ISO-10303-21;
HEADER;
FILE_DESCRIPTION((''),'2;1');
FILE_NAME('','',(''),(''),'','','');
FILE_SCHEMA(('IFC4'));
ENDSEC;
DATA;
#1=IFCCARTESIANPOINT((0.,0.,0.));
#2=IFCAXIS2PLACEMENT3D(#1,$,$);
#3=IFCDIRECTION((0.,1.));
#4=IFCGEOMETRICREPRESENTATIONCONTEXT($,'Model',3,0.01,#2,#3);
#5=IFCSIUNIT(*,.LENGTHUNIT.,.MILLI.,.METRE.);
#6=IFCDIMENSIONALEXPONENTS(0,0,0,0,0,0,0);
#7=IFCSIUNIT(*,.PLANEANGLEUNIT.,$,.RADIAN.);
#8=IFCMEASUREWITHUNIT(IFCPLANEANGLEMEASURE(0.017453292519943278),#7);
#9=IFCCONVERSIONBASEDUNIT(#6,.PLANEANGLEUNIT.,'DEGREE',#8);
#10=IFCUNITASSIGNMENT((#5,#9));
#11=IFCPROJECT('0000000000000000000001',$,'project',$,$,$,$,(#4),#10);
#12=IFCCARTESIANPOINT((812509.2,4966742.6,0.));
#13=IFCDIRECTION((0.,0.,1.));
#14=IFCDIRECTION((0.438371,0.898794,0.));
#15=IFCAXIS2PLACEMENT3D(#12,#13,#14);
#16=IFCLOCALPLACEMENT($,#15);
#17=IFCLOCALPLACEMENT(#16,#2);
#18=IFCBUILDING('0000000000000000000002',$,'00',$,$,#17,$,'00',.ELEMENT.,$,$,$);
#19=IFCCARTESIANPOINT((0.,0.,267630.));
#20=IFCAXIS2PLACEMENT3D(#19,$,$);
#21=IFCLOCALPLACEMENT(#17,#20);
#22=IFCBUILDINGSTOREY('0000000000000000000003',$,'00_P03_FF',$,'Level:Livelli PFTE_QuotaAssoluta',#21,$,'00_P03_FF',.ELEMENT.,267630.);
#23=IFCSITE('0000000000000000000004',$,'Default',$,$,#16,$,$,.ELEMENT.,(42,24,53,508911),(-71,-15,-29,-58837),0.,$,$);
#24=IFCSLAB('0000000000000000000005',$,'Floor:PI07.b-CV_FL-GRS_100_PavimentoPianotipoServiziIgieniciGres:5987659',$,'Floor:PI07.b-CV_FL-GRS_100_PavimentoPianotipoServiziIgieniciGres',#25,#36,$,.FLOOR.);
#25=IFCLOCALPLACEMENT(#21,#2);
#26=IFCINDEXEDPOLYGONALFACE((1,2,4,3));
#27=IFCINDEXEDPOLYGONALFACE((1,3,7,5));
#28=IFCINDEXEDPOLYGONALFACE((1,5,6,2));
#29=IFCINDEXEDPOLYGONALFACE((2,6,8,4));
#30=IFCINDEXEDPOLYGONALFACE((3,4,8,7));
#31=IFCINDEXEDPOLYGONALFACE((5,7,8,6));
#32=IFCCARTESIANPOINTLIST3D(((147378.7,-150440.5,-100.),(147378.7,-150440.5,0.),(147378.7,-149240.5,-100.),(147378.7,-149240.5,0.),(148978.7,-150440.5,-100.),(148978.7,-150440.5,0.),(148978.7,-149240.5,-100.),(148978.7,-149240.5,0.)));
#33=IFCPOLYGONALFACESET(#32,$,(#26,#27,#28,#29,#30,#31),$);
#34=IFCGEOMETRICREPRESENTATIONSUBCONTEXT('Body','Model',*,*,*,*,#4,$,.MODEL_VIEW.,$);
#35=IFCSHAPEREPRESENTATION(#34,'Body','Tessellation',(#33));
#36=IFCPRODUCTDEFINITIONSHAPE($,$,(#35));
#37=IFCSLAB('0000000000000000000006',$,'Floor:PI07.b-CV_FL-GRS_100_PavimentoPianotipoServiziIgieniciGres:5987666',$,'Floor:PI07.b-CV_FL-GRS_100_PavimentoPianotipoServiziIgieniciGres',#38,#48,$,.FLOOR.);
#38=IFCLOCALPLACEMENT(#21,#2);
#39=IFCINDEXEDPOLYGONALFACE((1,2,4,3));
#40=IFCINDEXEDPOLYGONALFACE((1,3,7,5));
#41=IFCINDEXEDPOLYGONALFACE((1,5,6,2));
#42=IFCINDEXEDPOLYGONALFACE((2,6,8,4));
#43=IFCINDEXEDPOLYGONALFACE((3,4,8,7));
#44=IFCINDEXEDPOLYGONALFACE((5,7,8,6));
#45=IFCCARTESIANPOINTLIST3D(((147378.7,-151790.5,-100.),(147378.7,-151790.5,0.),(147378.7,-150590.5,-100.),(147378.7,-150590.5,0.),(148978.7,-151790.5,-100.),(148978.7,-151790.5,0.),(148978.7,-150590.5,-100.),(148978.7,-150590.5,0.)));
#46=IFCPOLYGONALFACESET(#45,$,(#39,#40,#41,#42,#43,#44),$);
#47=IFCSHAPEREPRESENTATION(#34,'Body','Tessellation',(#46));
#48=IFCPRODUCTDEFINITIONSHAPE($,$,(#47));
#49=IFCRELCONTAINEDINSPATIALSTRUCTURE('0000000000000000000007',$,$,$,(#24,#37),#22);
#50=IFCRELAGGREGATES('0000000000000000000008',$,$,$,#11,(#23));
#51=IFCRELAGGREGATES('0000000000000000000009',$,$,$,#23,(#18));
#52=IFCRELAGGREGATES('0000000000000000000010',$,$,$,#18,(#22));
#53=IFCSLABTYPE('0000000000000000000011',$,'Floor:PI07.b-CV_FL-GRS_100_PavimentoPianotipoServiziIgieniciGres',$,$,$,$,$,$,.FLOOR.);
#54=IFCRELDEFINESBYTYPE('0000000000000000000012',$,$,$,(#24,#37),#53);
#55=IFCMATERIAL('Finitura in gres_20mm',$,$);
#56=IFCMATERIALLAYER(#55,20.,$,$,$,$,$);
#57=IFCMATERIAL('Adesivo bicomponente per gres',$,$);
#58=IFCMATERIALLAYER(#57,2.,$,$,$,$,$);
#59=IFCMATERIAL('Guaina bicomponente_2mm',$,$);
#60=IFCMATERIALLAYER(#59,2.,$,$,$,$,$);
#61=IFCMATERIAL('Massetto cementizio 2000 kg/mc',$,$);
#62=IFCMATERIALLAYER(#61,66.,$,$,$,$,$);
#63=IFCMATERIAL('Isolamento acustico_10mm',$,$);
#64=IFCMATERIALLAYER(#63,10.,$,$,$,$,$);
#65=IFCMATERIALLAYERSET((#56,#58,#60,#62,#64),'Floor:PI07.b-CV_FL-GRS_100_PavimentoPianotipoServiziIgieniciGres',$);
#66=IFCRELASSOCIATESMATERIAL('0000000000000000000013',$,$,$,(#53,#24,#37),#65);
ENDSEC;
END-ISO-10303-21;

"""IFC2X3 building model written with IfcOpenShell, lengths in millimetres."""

from ifc_helpers import new_model, entity, si_unit, converted_unit, direction, frame, frame_2d, origin, place, context, subcontext, project, spatial, rectangle, extrude, material, layer, layer_set, layer_usage, type_object, element, save


model = new_model("IFC2X3")

# Units and contexts
model_context = context("Model", 3, precision=0.01, world=origin(), true_north=direction((0.0, 1.0)))
body_context = subcontext(model_context, "Body", "Model", "MODEL_VIEW")
ifc_project = project(units=[si_unit("LENGTHUNIT", "METRE", prefix="MILLI"), converted_unit("PLANEANGLEUNIT", "DEGREE", entity("IfcPlaneAngleMeasure", 0.017453292519943278), si_unit("PLANEANGLEUNIT", "RADIAN"), dimensions=[0, 0, 0, 0, 0, 0, 0])], contexts=[model_context])

# Site, building, storey
site_placement = place(None, frame((812509.2, 4966742.6, 0.0), z_axis=(0.0, 0.0, 1.0), x_axis=(0.438371, 0.898794, 0.0)))
site = spatial("IfcSite", under=ifc_project, at=site_placement, Name="Default", CompositionType="ELEMENT", RefLatitude=(42, 24, 53, 508911), RefLongitude=(-71, -15, -29, -58837), RefElevation=0.0)
building_placement = place(site_placement, origin())
building = spatial("IfcBuilding", under=site, at=building_placement, Name="00", LongName="00", CompositionType="ELEMENT")
storey_placement = place(building_placement, frame((0.0, 0.0, 267630.0)))
storey = spatial("IfcBuildingStorey", under=building, at=storey_placement, Name="00_P03_FF", ObjectType="Level:Livelli PFTE_QuotaAssoluta", LongName="00_P03_FF", CompositionType="ELEMENT", Elevation=267630.0)

# Slabs
ifc_material_1 = material(Name="Massetto cementizio 2000 kg/mc")
ifc_material_2 = material(Name="Isolamento acustico_10mm")
ifc_material_3 = material(Name="Finitura in gres_20mm")
ifc_layer_1 = layer(ifc_material_3, 20.0)
ifc_material_4 = material(Name="Adesivo bicomponente per gres")
ifc_layer_2 = layer(ifc_material_4, 2.0)
ifc_material_5 = material(Name="Guaina bicomponente_2mm")
ifc_layer_3 = layer(ifc_material_5, 2.0)
ifc_layer_4 = layer(ifc_material_1, 66.0)
ifc_layer_5 = layer(ifc_material_2, 10.0)
ifc_layer_set_1 = layer_set([ifc_layer_1, ifc_layer_2, ifc_layer_3, ifc_layer_4, ifc_layer_5], Name="Floor:PI07.b-CV_FL-GRS_100_PavimentoPianotipoServiziIgieniciGres")
slab_type_1 = type_object("IfcSlabType", Name="Floor:PI07.b-CV_FL-GRS_100_PavimentoPianotipoServiziIgieniciGres", PredefinedType="FLOOR", material=ifc_layer_set_1)
ifc_layer_usage_1 = layer_usage(ifc_layer_set_1, "AXIS3", "POSITIVE", 0.0)
slab_1_placement = place(storey_placement, origin())
element("IfcSlab", 1, at=slab_1_placement, inside=storey, type_object=slab_type_1, material=ifc_layer_usage_1, Name="Floor:PI07.b-CV_FL-GRS_100_PavimentoPianotipoServiziIgieniciGres:5987659", ObjectType="Floor:PI07.b-CV_FL-GRS_100_PavimentoPianotipoServiziIgieniciGres", PredefinedType="FLOOR", context=body_context, shape_type="SweptSolid", body=[
    extrude(rectangle(XDim=1200.0, YDim=1600.0, at=frame_2d((0.0, 0.0), x_axis=(1.0, 0.0))), frame((148178.7, -149840.5, 0.0), z_axis=(0.0, 0.0, -1.0), x_axis=(0.0, 1.0, 0.0)), (0.0, 0.0, 1.0), 100.0),
])
ifc_layer_usage_2 = layer_usage(ifc_layer_set_1, "AXIS3", "POSITIVE", 0.0)
slab_2_placement = place(storey_placement, origin())
element("IfcSlab", 2, at=slab_2_placement, inside=storey, type_object=slab_type_1, material=ifc_layer_usage_2, Name="Floor:PI07.b-CV_FL-GRS_100_PavimentoPianotipoServiziIgieniciGres:5987666", ObjectType="Floor:PI07.b-CV_FL-GRS_100_PavimentoPianotipoServiziIgieniciGres", PredefinedType="FLOOR", context=body_context, shape_type="SweptSolid", body=[
    extrude(rectangle(XDim=1200.0, YDim=1600.0, at=frame_2d((0.0, 0.0), x_axis=(1.0, 0.0))), frame((148178.7, -151190.5, 0.0), z_axis=(0.0, 0.0, -1.0), x_axis=(0.0, 1.0, 0.0)), (0.0, 0.0, 1.0), 100.0),
])

save(model, "model.ifc")
